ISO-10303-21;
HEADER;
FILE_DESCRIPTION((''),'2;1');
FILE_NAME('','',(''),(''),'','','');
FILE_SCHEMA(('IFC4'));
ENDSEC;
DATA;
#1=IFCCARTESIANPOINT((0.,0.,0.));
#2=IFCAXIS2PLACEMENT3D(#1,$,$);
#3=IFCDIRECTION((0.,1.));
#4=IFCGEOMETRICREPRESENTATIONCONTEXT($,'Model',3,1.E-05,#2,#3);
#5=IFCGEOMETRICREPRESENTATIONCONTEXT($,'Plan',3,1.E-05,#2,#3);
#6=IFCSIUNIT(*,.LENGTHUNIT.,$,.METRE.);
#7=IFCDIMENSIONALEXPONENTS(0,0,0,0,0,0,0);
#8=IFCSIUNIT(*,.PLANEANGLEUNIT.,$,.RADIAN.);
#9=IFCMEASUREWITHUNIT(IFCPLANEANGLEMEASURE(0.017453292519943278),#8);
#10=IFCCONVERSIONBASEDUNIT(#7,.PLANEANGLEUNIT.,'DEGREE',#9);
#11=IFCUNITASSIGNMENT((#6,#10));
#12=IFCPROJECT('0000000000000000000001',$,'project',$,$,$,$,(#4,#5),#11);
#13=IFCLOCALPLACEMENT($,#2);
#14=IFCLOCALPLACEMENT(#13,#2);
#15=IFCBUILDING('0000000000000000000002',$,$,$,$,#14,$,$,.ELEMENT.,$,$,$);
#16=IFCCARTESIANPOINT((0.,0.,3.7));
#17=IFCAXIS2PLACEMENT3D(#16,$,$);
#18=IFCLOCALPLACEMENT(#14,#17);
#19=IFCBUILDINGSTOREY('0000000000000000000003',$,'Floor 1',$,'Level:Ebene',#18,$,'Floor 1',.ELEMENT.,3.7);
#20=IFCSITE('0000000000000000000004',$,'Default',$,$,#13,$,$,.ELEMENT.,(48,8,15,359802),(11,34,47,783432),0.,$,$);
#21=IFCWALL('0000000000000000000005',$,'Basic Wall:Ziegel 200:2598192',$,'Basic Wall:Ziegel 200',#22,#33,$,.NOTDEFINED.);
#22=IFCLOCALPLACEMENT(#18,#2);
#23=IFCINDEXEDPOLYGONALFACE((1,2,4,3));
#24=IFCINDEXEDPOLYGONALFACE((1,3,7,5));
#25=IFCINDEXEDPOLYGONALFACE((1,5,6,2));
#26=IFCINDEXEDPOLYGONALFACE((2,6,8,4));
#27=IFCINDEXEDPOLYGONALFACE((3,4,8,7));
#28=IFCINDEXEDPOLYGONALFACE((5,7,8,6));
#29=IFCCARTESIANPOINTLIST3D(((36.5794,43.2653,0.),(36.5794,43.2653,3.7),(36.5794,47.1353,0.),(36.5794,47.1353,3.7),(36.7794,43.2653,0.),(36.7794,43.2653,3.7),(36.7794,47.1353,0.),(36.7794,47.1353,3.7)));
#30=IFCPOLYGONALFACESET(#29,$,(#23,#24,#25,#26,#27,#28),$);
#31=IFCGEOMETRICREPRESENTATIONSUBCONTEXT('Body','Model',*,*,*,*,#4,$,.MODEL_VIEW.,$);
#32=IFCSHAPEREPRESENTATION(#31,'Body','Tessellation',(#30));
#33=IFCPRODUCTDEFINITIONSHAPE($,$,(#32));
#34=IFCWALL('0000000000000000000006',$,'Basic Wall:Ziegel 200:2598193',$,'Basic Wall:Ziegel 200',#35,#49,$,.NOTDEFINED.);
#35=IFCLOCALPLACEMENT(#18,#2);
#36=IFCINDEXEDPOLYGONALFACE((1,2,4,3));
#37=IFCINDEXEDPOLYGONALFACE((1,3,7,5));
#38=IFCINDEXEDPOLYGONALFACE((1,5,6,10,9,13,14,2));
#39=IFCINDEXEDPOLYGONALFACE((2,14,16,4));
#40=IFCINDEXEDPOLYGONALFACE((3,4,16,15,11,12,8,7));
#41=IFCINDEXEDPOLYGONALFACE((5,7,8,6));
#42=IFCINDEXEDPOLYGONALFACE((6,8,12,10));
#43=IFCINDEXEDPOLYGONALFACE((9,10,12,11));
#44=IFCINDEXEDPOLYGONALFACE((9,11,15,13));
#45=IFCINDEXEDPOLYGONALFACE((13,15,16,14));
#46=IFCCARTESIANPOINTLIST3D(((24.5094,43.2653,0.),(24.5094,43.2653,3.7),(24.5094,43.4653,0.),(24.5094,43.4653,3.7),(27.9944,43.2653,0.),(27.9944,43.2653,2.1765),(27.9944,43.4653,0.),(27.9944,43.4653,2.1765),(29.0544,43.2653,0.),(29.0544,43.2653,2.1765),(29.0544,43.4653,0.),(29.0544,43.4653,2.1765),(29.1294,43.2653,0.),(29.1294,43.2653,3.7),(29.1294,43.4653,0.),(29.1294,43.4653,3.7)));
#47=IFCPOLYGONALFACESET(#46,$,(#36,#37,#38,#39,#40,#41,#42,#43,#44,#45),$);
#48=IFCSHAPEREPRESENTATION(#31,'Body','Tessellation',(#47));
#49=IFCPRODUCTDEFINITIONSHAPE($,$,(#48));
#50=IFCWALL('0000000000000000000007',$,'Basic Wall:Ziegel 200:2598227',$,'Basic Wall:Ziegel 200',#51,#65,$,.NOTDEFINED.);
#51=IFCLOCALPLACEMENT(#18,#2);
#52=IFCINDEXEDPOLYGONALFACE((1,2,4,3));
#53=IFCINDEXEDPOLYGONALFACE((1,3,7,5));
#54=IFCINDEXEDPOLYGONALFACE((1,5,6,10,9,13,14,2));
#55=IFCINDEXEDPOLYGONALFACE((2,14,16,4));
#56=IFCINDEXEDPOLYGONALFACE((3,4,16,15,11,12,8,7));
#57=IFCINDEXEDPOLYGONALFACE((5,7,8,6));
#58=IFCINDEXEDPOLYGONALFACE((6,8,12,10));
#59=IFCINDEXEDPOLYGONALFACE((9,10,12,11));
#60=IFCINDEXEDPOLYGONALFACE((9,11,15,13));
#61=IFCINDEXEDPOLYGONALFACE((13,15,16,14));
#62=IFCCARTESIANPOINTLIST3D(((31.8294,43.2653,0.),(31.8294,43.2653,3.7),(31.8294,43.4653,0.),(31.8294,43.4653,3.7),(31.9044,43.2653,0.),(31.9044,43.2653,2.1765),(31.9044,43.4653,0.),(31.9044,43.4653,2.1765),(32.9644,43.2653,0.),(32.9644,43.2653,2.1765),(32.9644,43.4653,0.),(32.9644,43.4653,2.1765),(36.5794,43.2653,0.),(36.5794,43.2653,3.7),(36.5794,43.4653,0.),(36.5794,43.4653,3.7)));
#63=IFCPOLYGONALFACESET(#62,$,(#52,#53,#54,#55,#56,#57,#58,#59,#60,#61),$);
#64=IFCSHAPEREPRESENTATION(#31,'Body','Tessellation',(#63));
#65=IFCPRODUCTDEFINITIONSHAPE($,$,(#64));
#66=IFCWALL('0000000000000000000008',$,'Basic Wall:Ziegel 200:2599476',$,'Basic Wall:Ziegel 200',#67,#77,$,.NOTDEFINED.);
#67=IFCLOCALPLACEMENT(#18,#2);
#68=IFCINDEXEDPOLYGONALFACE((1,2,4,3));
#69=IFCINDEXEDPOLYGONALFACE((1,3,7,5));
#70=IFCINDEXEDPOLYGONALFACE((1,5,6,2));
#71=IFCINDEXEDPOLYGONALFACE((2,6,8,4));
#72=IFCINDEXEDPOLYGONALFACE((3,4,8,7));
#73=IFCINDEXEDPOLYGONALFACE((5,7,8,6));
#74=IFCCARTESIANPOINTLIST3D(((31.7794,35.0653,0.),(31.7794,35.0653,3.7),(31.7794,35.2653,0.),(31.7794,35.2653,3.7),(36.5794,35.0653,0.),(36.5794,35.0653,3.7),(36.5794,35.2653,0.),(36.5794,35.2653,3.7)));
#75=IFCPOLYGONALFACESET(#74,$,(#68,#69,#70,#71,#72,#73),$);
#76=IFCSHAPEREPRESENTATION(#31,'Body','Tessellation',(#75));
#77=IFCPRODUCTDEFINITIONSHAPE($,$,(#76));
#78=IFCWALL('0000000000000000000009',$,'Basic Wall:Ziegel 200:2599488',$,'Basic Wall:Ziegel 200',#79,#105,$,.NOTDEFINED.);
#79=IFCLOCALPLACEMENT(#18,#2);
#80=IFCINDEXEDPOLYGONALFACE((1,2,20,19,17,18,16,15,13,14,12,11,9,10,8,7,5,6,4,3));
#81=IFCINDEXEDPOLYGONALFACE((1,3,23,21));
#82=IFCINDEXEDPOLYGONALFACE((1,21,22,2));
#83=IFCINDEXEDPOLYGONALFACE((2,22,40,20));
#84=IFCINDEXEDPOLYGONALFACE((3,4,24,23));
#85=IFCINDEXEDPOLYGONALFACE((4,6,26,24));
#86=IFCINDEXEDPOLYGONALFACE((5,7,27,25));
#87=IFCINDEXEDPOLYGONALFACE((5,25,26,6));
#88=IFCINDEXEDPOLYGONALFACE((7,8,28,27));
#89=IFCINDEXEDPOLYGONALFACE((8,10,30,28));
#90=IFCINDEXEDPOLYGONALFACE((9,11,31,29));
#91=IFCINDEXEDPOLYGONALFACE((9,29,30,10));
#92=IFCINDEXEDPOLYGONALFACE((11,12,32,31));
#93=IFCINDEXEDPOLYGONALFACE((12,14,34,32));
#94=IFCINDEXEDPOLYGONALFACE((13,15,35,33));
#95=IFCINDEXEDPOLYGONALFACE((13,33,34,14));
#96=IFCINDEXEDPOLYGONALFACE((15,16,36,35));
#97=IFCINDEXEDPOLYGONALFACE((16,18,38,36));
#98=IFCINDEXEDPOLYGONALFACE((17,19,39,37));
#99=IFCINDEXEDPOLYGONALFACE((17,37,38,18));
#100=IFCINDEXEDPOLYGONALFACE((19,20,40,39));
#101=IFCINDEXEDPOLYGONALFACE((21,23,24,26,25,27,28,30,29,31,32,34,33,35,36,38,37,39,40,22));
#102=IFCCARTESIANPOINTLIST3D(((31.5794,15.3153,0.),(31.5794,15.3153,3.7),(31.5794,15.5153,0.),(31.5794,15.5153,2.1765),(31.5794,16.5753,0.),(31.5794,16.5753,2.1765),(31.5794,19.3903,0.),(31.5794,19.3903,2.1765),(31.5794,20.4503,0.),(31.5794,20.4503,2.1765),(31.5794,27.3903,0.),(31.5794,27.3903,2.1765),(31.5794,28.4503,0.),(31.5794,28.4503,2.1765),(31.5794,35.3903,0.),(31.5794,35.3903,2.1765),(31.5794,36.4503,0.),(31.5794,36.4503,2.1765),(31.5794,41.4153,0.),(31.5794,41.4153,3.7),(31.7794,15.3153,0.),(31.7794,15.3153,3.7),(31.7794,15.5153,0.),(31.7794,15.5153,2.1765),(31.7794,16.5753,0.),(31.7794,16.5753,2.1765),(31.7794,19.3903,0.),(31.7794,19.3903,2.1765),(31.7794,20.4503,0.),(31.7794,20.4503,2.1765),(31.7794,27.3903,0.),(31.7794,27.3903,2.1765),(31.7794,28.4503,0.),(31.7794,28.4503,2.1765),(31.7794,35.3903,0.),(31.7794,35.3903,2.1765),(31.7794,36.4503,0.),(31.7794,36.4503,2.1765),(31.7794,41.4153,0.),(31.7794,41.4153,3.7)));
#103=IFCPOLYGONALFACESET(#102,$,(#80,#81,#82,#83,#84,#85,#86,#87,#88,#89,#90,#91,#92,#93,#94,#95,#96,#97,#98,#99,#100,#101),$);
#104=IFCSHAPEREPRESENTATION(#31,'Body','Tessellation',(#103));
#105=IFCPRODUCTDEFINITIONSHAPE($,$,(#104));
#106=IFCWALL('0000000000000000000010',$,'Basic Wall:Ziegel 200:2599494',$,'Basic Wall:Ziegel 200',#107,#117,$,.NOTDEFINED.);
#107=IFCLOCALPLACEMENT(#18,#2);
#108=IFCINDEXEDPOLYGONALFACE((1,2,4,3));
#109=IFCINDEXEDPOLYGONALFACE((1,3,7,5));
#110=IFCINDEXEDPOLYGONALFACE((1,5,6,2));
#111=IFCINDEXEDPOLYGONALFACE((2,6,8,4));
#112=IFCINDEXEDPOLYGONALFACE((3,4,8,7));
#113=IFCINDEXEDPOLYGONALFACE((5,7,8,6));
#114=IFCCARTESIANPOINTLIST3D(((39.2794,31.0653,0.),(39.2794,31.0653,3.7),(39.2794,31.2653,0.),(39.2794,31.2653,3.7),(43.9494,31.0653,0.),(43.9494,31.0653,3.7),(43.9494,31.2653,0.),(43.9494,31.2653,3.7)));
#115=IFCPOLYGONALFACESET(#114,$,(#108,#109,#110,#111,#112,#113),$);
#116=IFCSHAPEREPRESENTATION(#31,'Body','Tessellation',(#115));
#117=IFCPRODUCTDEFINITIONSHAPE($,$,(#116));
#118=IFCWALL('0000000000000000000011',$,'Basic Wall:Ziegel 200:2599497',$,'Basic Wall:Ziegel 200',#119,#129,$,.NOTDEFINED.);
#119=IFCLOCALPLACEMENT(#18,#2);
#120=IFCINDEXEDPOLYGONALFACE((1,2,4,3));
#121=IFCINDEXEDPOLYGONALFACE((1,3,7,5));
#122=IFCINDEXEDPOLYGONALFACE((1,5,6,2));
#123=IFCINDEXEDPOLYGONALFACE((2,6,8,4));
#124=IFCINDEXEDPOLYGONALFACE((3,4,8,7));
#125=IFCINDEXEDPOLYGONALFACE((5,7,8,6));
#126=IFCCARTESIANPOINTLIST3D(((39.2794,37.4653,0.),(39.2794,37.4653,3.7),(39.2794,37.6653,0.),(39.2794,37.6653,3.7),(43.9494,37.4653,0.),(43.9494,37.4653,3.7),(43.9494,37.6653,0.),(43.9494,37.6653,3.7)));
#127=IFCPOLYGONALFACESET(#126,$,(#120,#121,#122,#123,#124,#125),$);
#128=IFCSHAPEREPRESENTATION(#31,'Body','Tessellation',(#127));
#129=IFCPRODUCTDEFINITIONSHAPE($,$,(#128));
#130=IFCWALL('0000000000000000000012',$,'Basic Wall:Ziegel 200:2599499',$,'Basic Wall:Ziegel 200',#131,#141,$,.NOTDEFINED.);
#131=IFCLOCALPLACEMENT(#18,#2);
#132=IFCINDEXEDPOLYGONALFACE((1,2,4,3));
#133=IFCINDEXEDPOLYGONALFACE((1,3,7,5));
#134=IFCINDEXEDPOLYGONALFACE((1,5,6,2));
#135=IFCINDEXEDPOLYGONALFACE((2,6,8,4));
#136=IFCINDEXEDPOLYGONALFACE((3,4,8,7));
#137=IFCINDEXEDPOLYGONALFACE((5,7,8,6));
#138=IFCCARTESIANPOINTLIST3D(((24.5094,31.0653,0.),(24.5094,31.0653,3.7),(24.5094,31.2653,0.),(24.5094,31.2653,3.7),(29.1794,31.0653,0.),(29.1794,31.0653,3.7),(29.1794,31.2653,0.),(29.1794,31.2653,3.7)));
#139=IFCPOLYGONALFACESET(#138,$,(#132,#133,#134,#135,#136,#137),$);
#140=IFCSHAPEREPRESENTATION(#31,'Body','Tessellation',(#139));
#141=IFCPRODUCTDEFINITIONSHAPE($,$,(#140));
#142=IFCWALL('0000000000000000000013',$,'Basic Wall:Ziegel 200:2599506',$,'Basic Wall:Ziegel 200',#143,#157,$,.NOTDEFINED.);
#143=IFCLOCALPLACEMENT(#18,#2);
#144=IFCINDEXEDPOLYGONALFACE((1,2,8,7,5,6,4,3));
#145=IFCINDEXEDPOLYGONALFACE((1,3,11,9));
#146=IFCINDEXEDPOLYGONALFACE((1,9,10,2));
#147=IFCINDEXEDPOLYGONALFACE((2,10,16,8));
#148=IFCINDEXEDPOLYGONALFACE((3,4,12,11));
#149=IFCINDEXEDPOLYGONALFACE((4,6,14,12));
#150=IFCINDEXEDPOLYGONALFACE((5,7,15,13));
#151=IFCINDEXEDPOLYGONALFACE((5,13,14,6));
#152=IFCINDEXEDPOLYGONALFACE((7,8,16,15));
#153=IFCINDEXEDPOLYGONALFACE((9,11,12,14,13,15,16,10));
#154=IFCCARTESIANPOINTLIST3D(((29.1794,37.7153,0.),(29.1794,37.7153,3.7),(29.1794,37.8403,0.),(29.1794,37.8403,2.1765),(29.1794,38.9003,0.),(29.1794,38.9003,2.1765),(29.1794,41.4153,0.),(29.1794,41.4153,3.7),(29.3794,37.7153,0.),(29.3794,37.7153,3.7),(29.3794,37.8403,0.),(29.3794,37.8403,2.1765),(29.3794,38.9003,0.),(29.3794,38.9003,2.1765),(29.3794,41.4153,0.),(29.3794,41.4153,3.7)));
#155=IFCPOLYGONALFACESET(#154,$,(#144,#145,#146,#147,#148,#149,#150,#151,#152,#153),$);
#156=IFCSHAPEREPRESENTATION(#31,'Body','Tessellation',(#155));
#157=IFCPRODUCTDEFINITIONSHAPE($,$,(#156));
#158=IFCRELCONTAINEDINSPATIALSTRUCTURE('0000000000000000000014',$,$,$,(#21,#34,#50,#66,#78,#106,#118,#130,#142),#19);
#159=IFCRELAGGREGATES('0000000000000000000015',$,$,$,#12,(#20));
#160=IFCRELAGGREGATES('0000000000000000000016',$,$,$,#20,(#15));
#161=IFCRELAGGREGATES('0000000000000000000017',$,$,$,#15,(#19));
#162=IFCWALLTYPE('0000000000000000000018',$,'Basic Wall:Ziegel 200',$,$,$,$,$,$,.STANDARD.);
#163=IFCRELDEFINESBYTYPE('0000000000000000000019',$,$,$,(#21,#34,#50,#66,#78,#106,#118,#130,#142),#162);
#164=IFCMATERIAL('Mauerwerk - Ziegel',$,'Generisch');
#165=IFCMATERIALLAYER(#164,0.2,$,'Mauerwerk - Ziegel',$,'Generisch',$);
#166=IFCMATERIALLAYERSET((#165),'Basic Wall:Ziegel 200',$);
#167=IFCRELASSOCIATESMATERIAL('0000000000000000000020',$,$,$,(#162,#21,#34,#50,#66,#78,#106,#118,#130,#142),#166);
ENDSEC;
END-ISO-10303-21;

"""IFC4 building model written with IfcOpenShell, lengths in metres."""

from ifc_helpers import new_model, entity, si_unit, converted_unit, direction, frame, frame_2d, origin, place, context, subcontext, project, spatial, rectangle, extrude, material, layer, layer_set, layer_usage, type_object, element, save


model = new_model("IFC4")

# Units and contexts
model_context = context("Model", 3, precision=1e-05, world=origin(), true_north=direction((0.0, 1.0)))
plan_context = context("Plan", 3, precision=1e-05, world=origin(), true_north=direction((0.0, 1.0)))
body_context = subcontext(model_context, "Body", "Model", "MODEL_VIEW")
ifc_project = project(units=[si_unit("LENGTHUNIT", "METRE"), converted_unit("PLANEANGLEUNIT", "DEGREE", entity("IfcPlaneAngleMeasure", 0.017453292519943278), si_unit("PLANEANGLEUNIT", "RADIAN"), dimensions=[0, 0, 0, 0, 0, 0, 0])], contexts=[model_context, plan_context])

# Site, building, storey
site_placement = place(None, origin())
site = spatial("IfcSite", under=ifc_project, at=site_placement, Name="Default", CompositionType="ELEMENT", RefLatitude=(48, 8, 15, 359802), RefLongitude=(11, 34, 47, 783432), RefElevation=0.0)
building_placement = place(site_placement, origin())
building = spatial("IfcBuilding", under=site, at=building_placement, CompositionType="ELEMENT")
storey_placement = place(building_placement, frame((0.0, 0.0, 3.7)))
storey = spatial("IfcBuildingStorey", under=building, at=storey_placement, Name="Floor 1", ObjectType="Level:Ebene", LongName="Floor 1", CompositionType="ELEMENT", Elevation=3.7)

# Shared definitions
ifc_material_1 = material(Name="Mauerwerk - Ziegel", Category="Generisch")
ifc_layer_1 = layer(ifc_material_1, 0.2, Name="Mauerwerk - Ziegel", Category="Generisch")
ifc_layer_set_1 = layer_set([ifc_layer_1], Name="Basic Wall:Ziegel 200")
ifc_layer_usage_1 = layer_usage(ifc_layer_set_1, "AXIS2", "NEGATIVE", 0.1)
wall_type_1 = type_object("IfcWallType", Name="Basic Wall:Ziegel 200", PredefinedType="STANDARD", material=ifc_layer_set_1)

# Wall
wall_1_placement = place(storey_placement, frame((36.6794, 47.1353, 0.0), z_axis=(0.0, 0.0, 1.0), x_axis=(0.0, -1.0, 0.0)))
element("IfcWall", 1, at=wall_1_placement, inside=storey, type_object=wall_type_1, material=ifc_layer_usage_1, Name="Basic Wall:Ziegel 200:2598192", ObjectType="Basic Wall:Ziegel 200", PredefinedType="NOTDEFINED", context=body_context, shape_type="SweptSolid", body=[
    extrude(rectangle(XDim=3.87, YDim=0.2, at=frame_2d((1.935, 0.0), x_axis=(-1.0, 0.0))), origin(), (0.0, 0.0, 1.0), 3.7),
])

# Walls, openings
wall_2_placement = place(storey_placement, frame((29.1294, 43.3653, 0.0), z_axis=(0.0, 0.0, 1.0), x_axis=(-1.0, 0.0, 0.0)))
wall_2 = element("IfcWall", 2, at=wall_2_placement, inside=storey, type_object=wall_type_1, material=ifc_layer_usage_1, Name="Basic Wall:Ziegel 200:2598193", ObjectType="Basic Wall:Ziegel 200", PredefinedType="NOTDEFINED", context=body_context, shape_type="SweptSolid", body=[
    extrude(rectangle(XDim=4.62, YDim=0.2, at=frame_2d((2.31, 0.0), x_axis=(-1.0, 0.0))), origin(), (0.0, 0.0, 1.0), 3.7),
])
opening_1_placement = place(wall_2_placement, frame((0.075, -0.1, 0.0)))
element("IfcOpeningElement", 3, at=opening_1_placement, cuts=wall_2, PredefinedType="OPENING", context=body_context, shape_type="SweptSolid", body=[
    extrude(rectangle(XDim=2.1765, YDim=1.06, at=frame_2d((1.0882, 0.53), x_axis=(1.0, 0.0))), frame((0.0, 0.0, 0.0), z_axis=(0.0, 1.0, 0.0), x_axis=(0.0, 0.0, 1.0)), (0.0, 0.0, 1.0), 0.2),
])
wall_3_placement = place(storey_placement, frame((31.8294, 43.3653, 0.0)))
wall_3 = element("IfcWall", 4, at=wall_3_placement, inside=storey, type_object=wall_type_1, material=ifc_layer_usage_1, Name="Basic Wall:Ziegel 200:2598227", ObjectType="Basic Wall:Ziegel 200", PredefinedType="NOTDEFINED", context=body_context, shape_type="SweptSolid", body=[
    extrude(rectangle(XDim=4.75, YDim=0.2, at=frame_2d((2.375, 0.0), x_axis=(-1.0, 0.0))), origin(), (0.0, 0.0, 1.0), 3.7),
])
opening_2_placement = place(wall_3_placement, frame((1.135, 0.1, 0.0)))
element("IfcOpeningElement", 5, at=opening_2_placement, cuts=wall_3, PredefinedType="OPENING", context=body_context, shape_type="SweptSolid", body=[
    extrude(rectangle(XDim=2.1765, YDim=1.06, at=frame_2d((1.0882, 0.53), x_axis=(1.0, 0.0))), frame((0.0, 0.0, 0.0), z_axis=(0.0, -1.0, 0.0), x_axis=(0.0, 0.0, 1.0)), (0.0, 0.0, 1.0), 0.2),
])

# Wall
wall_4_placement = place(storey_placement, frame((36.5794, 35.1653, 0.0), z_axis=(0.0, 0.0, 1.0), x_axis=(-1.0, 0.0, 0.0)))
element("IfcWall", 6, at=wall_4_placement, inside=storey, type_object=wall_type_1, material=ifc_layer_usage_1, Name="Basic Wall:Ziegel 200:2599476", ObjectType="Basic Wall:Ziegel 200", PredefinedType="NOTDEFINED", context=body_context, shape_type="SweptSolid", body=[
    extrude(rectangle(XDim=4.8, YDim=0.2, at=frame_2d((2.4, 0.0), x_axis=(-1.0, 0.0))), origin(), (0.0, 0.0, 1.0), 3.7),
])

# Wall, openings
wall_5_placement = place(storey_placement, frame((31.6794, 41.4153, 0.0), z_axis=(0.0, 0.0, 1.0), x_axis=(0.0, -1.0, 0.0)))
wall_5 = element("IfcWall", 7, at=wall_5_placement, inside=storey, type_object=wall_type_1, material=ifc_layer_usage_1, Name="Basic Wall:Ziegel 200:2599488", ObjectType="Basic Wall:Ziegel 200", PredefinedType="NOTDEFINED", context=body_context, shape_type="SweptSolid", body=[
    extrude(rectangle(XDim=26.1, YDim=0.2, at=frame_2d((13.05, 0.0), x_axis=(1.0, 0.0))), origin(), (0.0, 0.0, 1.0), 3.7),
])
opening_3_placement = place(wall_5_placement, frame((22.025, 0.1, 0.0)))
element("IfcOpeningElement", 8, at=opening_3_placement, cuts=wall_5, PredefinedType="OPENING", context=body_context, shape_type="SweptSolid", body=[
    extrude(rectangle(XDim=2.1765, YDim=1.06, at=frame_2d((1.0882, 0.53), x_axis=(1.0, 0.0))), frame((0.0, 0.0, 0.0), z_axis=(0.0, -1.0, 0.0), x_axis=(0.0, 0.0, 1.0)), (0.0, 0.0, 1.0), 0.2),
])
opening_4_placement = place(wall_5_placement, frame((6.025, 0.1, 0.0)))
element("IfcOpeningElement", 9, at=opening_4_placement, cuts=wall_5, PredefinedType="OPENING", context=body_context, shape_type="SweptSolid", body=[
    extrude(rectangle(XDim=2.1765, YDim=1.06, at=frame_2d((1.0882, 0.53), x_axis=(1.0, 0.0))), frame((0.0, 0.0, 0.0), z_axis=(0.0, -1.0, 0.0), x_axis=(0.0, 0.0, 1.0)), (0.0, 0.0, 1.0), 0.2),
])
opening_5_placement = place(wall_5_placement, frame((14.025, 0.1, 0.0)))
element("IfcOpeningElement", 10, at=opening_5_placement, cuts=wall_5, PredefinedType="OPENING", context=body_context, shape_type="SweptSolid", body=[
    extrude(rectangle(XDim=2.1765, YDim=1.06, at=frame_2d((1.0882, 0.53), x_axis=(1.0, 0.0))), frame((0.0, 0.0, 0.0), z_axis=(0.0, -1.0, 0.0), x_axis=(0.0, 0.0, 1.0)), (0.0, 0.0, 1.0), 0.2),
])
opening_6_placement = place(wall_5_placement, frame((24.84, -0.1, 0.0)))
element("IfcOpeningElement", 11, at=opening_6_placement, cuts=wall_5, PredefinedType="OPENING", context=body_context, shape_type="SweptSolid", body=[
    extrude(rectangle(XDim=2.1765, YDim=1.06, at=frame_2d((1.0882, 0.53), x_axis=(1.0, 0.0))), frame((0.0, 0.0, 0.0), z_axis=(0.0, 1.0, 0.0), x_axis=(0.0, 0.0, 1.0)), (0.0, 0.0, 1.0), 0.2),
])

# Walls
wall_6_placement = place(storey_placement, frame((39.2794, 31.1653, 0.0)))
element("IfcWall", 12, at=wall_6_placement, inside=storey, type_object=wall_type_1, material=ifc_layer_usage_1, Name="Basic Wall:Ziegel 200:2599494", ObjectType="Basic Wall:Ziegel 200", PredefinedType="NOTDEFINED", context=body_context, shape_type="SweptSolid", body=[
    extrude(rectangle(XDim=4.67, YDim=0.2, at=frame_2d((2.335, 0.0), x_axis=(-1.0, 0.0))), origin(), (0.0, 0.0, 1.0), 3.7),
])
wall_7_placement = place(storey_placement, frame((43.9494, 37.5653, 0.0), z_axis=(0.0, 0.0, 1.0), x_axis=(-1.0, 0.0, 0.0)))
element("IfcWall", 13, at=wall_7_placement, inside=storey, type_object=wall_type_1, material=ifc_layer_usage_1, Name="Basic Wall:Ziegel 200:2599497", ObjectType="Basic Wall:Ziegel 200", PredefinedType="NOTDEFINED", context=body_context, shape_type="SweptSolid", body=[
    extrude(rectangle(XDim=4.67, YDim=0.2, at=frame_2d((2.335, 0.0), x_axis=(-1.0, 0.0))), origin(), (0.0, 0.0, 1.0), 3.7),
])
wall_8_placement = place(storey_placement, frame((29.1794, 31.1653, 0.0), z_axis=(0.0, 0.0, 1.0), x_axis=(-1.0, 0.0, 0.0)))
element("IfcWall", 14, at=wall_8_placement, inside=storey, type_object=wall_type_1, material=ifc_layer_usage_1, Name="Basic Wall:Ziegel 200:2599499", ObjectType="Basic Wall:Ziegel 200", PredefinedType="NOTDEFINED", context=body_context, shape_type="SweptSolid", body=[
    extrude(rectangle(XDim=4.67, YDim=0.2, at=frame_2d((2.335, 0.0), x_axis=(-1.0, 0.0))), origin(), (0.0, 0.0, 1.0), 3.7),
])

# Wall, opening
wall_9_placement = place(storey_placement, frame((29.2794, 41.4153, 0.0), z_axis=(0.0, 0.0, 1.0), x_axis=(0.0, -1.0, 0.0)))
wall_9 = element("IfcWall", 15, at=wall_9_placement, inside=storey, type_object=wall_type_1, material=ifc_layer_usage_1, Name="Basic Wall:Ziegel 200:2599506", ObjectType="Basic Wall:Ziegel 200", PredefinedType="NOTDEFINED", context=body_context, shape_type="SweptSolid", body=[
    extrude(rectangle(XDim=3.7, YDim=0.2, at=frame_2d((1.85, 0.0), x_axis=(1.0, 0.0))), origin(), (0.0, 0.0, 1.0), 3.7),
])
opening_7_placement = place(wall_9_placement, frame((2.515, -0.1, 0.0)))
element("IfcOpeningElement", 16, at=opening_7_placement, cuts=wall_9, PredefinedType="OPENING", context=body_context, shape_type="SweptSolid", body=[
    extrude(rectangle(XDim=2.1765, YDim=1.06, at=frame_2d((1.0882, 0.53), x_axis=(1.0, 0.0))), frame((0.0, 0.0, 0.0), z_axis=(0.0, 1.0, 0.0), x_axis=(0.0, 0.0, 1.0)), (0.0, 0.0, 1.0), 0.2),
])

save(model, "model.ifc")
